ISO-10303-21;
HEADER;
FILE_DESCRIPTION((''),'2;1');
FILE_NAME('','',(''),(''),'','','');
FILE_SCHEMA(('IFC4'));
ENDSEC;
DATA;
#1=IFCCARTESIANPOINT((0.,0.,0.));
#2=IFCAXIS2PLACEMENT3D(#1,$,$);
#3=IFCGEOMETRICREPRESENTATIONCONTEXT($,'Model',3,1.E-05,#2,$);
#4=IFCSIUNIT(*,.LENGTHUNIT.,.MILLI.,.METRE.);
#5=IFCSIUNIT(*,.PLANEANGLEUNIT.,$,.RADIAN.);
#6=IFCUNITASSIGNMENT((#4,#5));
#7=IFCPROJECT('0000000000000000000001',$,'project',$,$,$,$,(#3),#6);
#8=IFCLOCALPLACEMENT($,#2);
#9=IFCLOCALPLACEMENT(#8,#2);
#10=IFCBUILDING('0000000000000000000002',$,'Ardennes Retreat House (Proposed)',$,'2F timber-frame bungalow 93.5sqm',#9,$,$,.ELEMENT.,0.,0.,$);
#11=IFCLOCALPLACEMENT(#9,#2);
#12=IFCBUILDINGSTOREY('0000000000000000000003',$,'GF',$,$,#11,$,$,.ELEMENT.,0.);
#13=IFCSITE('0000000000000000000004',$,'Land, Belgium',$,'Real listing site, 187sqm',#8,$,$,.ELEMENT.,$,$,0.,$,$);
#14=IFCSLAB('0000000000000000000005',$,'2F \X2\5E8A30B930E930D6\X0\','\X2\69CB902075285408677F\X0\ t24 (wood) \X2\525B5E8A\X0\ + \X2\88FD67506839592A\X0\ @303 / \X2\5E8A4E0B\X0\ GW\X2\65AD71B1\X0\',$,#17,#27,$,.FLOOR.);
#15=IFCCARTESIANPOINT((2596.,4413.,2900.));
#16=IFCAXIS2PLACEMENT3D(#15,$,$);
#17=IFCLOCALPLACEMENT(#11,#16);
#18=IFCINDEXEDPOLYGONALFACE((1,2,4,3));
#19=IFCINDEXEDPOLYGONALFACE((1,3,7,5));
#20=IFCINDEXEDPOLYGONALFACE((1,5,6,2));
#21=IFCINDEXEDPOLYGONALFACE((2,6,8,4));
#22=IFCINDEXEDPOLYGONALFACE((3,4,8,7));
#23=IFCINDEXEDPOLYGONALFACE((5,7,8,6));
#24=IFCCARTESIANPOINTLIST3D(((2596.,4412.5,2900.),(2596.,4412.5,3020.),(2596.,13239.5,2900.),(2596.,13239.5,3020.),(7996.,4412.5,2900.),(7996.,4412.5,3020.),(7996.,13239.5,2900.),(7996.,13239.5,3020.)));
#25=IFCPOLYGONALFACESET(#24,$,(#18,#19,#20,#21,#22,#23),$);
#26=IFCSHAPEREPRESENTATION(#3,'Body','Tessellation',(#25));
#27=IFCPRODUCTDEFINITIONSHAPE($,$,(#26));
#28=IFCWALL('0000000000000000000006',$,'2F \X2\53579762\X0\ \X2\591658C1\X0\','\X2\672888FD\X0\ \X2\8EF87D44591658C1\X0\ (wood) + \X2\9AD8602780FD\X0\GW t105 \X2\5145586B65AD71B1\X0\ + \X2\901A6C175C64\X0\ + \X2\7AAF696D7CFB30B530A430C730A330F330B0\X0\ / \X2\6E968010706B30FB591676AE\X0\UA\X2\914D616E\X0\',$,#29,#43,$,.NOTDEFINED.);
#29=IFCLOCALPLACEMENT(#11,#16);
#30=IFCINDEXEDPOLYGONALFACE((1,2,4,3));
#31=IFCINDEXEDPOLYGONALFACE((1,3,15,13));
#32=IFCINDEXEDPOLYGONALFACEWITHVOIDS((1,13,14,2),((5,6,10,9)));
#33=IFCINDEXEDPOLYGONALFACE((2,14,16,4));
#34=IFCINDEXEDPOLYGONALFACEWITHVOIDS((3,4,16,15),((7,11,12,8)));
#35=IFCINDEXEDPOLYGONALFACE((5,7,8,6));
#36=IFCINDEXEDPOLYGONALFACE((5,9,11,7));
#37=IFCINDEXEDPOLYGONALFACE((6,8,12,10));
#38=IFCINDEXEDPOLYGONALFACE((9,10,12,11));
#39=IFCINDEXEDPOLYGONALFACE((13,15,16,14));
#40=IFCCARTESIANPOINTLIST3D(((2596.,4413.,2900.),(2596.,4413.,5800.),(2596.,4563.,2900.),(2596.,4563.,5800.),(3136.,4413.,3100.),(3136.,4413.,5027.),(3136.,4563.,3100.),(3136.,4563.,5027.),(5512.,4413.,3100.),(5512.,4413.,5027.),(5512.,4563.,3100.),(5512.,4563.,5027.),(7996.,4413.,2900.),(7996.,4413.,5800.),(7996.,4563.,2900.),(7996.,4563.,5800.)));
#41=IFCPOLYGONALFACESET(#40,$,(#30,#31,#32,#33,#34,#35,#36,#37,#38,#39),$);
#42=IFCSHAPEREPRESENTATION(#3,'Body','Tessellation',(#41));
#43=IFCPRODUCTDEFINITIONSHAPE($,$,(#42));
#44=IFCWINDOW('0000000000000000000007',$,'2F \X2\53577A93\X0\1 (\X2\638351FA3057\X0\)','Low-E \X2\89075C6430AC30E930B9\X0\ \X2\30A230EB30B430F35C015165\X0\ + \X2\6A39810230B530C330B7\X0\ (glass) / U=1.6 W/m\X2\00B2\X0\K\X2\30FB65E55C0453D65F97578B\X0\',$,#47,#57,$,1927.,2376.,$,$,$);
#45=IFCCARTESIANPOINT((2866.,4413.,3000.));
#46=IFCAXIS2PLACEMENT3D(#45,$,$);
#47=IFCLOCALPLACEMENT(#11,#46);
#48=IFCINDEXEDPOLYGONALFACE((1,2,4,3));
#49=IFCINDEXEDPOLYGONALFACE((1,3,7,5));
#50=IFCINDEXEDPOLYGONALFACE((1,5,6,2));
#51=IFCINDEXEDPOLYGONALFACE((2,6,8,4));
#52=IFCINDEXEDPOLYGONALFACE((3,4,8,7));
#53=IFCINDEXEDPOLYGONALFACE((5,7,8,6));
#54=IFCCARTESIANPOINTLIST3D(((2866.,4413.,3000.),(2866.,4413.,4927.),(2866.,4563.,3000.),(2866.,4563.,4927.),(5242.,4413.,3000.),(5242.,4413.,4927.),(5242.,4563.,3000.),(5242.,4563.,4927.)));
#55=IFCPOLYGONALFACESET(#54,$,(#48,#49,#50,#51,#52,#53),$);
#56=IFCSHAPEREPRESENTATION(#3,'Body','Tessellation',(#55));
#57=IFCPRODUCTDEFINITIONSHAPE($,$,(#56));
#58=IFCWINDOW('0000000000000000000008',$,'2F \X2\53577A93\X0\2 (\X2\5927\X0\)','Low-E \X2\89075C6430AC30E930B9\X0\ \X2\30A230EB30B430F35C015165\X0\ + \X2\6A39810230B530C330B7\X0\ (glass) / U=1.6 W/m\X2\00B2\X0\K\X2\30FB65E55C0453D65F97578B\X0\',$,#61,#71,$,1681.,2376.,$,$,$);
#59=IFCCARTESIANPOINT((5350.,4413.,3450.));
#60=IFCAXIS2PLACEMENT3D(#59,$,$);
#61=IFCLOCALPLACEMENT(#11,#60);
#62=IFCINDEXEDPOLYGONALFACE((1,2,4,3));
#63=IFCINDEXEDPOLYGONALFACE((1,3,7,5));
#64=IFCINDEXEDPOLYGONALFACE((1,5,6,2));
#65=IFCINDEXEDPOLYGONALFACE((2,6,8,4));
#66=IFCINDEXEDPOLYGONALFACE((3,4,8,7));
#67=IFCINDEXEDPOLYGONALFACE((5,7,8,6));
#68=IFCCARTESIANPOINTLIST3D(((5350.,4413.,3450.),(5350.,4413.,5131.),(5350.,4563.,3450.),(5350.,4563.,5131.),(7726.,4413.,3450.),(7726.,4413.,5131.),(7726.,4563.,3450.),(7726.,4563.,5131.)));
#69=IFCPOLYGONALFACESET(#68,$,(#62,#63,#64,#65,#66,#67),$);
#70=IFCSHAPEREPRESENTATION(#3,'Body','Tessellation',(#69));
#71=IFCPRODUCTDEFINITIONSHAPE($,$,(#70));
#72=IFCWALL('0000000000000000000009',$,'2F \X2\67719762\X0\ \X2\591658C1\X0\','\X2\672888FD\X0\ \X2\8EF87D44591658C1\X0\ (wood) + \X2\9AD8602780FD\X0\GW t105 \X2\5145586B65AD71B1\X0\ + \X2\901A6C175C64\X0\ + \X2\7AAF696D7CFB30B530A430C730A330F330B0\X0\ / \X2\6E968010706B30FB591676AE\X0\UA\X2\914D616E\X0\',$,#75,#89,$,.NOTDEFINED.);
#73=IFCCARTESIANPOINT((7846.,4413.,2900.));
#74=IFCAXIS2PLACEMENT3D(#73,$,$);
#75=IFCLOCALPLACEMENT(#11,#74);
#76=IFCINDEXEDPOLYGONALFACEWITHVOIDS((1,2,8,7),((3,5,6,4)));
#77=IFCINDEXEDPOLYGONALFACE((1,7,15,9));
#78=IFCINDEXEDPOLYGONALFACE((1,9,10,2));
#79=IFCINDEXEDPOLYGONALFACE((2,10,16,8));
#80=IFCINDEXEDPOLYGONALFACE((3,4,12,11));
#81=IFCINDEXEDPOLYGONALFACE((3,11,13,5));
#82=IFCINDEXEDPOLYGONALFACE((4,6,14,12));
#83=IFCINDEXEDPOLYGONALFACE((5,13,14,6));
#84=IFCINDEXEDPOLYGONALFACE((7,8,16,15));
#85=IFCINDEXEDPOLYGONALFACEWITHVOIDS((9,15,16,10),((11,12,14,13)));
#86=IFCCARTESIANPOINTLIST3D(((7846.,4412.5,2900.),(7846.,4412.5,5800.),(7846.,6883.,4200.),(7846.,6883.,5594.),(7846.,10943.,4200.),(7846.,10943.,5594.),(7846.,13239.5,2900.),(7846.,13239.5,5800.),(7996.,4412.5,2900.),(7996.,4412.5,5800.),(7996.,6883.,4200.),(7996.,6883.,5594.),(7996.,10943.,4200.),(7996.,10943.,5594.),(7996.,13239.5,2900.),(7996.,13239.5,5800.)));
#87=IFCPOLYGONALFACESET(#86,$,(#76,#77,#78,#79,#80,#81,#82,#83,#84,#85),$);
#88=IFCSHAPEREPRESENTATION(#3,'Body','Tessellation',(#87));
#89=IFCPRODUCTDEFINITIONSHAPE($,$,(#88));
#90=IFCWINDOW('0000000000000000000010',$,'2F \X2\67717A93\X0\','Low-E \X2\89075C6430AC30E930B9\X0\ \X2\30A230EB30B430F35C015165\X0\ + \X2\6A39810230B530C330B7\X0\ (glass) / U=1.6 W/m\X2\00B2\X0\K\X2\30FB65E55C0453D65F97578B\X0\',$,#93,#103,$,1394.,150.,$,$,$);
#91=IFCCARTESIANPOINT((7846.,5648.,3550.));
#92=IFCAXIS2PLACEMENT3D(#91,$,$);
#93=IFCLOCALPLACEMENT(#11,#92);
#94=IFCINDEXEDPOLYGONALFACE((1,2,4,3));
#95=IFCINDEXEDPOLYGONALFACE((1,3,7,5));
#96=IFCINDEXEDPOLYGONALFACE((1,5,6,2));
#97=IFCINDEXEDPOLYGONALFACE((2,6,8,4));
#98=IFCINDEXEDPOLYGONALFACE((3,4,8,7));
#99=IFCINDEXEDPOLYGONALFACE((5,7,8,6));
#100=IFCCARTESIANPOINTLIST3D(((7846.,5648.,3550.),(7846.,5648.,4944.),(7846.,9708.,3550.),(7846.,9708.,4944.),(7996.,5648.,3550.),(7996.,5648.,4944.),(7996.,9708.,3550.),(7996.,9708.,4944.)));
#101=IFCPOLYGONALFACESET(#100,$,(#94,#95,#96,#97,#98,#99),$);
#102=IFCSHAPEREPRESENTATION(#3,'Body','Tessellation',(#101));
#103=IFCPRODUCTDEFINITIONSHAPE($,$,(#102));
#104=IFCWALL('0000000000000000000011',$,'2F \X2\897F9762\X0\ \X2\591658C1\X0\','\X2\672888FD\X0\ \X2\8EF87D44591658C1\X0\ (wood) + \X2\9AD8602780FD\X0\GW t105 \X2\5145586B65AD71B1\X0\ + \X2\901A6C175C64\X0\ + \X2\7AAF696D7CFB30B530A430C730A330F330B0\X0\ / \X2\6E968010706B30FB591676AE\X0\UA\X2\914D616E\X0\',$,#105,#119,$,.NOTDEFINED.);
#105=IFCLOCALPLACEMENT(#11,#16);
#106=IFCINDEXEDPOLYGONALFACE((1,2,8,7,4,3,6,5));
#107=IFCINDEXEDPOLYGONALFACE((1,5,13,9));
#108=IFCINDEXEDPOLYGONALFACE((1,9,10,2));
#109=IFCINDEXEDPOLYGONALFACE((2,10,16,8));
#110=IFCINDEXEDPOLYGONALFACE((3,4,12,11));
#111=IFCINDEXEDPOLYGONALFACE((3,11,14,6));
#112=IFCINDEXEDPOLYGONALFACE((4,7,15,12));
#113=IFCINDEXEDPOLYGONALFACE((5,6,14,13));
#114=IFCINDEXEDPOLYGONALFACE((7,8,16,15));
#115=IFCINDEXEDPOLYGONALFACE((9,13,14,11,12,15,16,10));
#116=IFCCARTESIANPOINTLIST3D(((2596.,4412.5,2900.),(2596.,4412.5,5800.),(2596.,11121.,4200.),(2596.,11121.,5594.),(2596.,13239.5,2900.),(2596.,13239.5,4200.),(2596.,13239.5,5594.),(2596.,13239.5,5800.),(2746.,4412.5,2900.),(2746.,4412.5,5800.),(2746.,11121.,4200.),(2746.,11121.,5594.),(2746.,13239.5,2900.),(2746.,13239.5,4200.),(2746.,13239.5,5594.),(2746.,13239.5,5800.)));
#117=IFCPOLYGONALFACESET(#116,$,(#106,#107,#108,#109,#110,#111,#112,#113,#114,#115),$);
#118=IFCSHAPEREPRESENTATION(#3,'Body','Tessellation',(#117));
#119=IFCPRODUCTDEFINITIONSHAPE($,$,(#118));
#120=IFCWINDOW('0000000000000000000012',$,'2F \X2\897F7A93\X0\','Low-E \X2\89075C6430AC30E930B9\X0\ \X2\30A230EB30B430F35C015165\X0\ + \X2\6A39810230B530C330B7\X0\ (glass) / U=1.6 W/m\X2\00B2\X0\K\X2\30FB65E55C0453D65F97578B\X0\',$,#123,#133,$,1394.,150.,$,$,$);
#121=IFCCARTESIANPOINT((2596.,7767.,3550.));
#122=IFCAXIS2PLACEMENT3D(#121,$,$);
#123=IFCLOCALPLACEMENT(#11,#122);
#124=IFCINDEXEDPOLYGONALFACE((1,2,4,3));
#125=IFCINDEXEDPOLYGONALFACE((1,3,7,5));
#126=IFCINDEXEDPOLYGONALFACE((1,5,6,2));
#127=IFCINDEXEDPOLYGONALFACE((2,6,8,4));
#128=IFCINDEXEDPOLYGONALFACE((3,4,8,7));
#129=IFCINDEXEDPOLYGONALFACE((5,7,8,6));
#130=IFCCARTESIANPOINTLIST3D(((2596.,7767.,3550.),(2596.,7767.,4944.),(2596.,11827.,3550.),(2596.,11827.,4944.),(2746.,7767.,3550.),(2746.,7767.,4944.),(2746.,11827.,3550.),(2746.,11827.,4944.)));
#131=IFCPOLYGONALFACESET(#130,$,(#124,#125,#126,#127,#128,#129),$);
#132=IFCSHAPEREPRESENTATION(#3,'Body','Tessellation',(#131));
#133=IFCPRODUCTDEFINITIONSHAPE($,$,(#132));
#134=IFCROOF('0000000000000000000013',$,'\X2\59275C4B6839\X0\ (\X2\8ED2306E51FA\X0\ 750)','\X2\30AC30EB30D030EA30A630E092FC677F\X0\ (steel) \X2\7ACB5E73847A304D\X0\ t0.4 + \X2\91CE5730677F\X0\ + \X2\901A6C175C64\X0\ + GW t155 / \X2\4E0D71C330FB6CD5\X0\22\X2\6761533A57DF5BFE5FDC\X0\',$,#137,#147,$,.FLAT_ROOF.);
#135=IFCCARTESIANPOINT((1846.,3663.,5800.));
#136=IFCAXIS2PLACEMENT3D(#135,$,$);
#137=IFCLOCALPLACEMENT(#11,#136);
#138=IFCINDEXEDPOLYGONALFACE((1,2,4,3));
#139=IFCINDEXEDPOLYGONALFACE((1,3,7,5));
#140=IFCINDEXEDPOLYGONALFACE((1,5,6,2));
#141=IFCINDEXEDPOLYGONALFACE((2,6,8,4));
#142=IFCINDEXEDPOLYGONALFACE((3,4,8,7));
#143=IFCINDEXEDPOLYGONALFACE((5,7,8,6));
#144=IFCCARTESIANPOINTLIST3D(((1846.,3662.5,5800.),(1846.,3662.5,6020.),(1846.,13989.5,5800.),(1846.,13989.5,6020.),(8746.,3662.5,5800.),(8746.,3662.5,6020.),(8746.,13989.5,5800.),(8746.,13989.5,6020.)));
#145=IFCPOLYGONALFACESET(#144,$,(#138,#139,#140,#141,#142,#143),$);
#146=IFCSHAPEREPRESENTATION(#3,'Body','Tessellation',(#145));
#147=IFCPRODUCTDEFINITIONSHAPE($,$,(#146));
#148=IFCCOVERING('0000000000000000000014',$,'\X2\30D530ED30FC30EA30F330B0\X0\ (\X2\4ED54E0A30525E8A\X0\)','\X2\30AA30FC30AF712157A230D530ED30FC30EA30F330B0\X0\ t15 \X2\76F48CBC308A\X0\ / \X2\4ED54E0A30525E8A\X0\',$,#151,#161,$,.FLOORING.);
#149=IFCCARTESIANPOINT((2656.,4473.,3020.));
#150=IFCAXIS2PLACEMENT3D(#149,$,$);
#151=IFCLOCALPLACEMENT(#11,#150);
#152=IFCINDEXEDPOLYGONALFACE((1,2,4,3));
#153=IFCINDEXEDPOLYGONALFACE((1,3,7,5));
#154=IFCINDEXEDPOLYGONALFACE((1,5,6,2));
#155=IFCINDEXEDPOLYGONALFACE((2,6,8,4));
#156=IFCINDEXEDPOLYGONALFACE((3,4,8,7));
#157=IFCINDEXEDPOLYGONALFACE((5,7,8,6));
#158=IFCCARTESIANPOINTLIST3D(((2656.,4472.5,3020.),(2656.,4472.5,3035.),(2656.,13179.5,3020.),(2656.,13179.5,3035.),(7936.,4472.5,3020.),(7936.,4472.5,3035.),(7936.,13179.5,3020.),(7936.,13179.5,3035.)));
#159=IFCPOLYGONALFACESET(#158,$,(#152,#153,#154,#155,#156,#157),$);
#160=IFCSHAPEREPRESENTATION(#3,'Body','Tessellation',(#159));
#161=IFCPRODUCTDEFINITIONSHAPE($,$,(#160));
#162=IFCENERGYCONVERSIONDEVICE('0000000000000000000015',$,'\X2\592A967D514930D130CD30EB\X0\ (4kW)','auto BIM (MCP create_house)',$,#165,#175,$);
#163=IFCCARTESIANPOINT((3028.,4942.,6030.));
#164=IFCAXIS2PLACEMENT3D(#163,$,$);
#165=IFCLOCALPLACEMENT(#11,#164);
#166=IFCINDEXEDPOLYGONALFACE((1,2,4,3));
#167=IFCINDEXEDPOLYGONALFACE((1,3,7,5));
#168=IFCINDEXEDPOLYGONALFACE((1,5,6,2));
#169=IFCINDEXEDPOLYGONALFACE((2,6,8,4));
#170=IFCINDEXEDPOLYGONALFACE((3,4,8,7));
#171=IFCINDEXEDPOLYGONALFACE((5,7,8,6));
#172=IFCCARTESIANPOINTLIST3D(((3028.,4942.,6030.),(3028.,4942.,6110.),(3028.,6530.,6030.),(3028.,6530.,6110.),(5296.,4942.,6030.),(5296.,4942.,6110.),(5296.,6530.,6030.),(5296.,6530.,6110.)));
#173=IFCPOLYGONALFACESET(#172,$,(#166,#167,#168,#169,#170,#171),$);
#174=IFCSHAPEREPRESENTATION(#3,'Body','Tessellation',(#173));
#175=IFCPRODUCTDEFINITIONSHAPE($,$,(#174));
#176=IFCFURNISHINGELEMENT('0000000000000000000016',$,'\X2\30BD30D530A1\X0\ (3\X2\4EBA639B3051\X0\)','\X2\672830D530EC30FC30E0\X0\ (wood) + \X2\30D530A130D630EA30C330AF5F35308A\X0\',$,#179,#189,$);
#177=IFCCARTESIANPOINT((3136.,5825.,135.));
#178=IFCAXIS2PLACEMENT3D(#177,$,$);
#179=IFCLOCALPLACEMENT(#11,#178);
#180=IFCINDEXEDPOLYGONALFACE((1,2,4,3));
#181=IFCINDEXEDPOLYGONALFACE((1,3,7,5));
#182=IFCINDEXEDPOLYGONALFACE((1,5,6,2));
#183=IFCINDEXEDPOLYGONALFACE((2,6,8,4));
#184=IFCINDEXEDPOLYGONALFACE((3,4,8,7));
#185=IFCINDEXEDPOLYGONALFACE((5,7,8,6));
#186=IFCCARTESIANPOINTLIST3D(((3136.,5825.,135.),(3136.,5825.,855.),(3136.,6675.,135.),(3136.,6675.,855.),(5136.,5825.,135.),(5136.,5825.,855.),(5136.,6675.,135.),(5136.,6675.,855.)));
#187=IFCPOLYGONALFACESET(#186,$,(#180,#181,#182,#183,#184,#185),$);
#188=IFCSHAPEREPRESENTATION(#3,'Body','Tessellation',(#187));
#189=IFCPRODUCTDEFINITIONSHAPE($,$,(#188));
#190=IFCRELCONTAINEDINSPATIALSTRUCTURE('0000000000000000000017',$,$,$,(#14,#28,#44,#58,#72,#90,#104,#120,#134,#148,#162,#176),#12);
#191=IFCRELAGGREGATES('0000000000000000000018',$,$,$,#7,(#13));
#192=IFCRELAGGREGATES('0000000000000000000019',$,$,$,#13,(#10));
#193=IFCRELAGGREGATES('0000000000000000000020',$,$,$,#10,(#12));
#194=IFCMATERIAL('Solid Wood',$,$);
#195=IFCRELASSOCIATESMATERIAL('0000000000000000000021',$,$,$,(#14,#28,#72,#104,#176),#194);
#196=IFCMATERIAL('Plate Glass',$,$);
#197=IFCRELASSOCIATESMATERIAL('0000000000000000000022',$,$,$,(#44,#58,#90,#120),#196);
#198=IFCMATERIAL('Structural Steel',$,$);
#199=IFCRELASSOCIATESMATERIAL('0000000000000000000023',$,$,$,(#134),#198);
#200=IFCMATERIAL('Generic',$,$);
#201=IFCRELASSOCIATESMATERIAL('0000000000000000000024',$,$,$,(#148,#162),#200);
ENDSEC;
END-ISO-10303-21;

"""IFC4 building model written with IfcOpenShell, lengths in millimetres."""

from ifc_helpers import new_model, si_unit, frame, frame_2d, origin, place, context, project, spatial, rectangle, extrude, material, element, fill, save


model = new_model("IFC4")

# Units and contexts
model_context = context("Model", 3, precision=1e-05, world=origin())
ifc_project = project(units=[si_unit("LENGTHUNIT", "METRE", prefix="MILLI"), si_unit("PLANEANGLEUNIT", "RADIAN")], contexts=[model_context])

# Site, building, storey
site_placement = place(None, origin())
site = spatial("IfcSite", under=ifc_project, at=site_placement, Name="Land, Belgium", ObjectType="Real listing site, 187sqm", CompositionType="ELEMENT", RefElevation=0.0)
building_placement = place(site_placement, origin())
building = spatial("IfcBuilding", under=site, at=building_placement, Name="Ardennes Retreat House (Proposed)", ObjectType="2F timber-frame bungalow 93.5sqm", CompositionType="ELEMENT", ElevationOfRefHeight=0.0, ElevationOfTerrain=0.0)
storey_placement = place(building_placement, origin())
storey = spatial("IfcBuildingStorey", under=building, at=storey_placement, Name="GF", CompositionType="ELEMENT", Elevation=0.0)

# Slab
ifc_material_1 = material(Name="Solid Wood")
slab_placement = place(storey_placement, frame((2596.0, 4413.0, 2900.0)))
element("IfcSlab", 1, at=slab_placement, inside=storey, material=ifc_material_1, Name="2F 床スラブ", Description="構造用合板 t24 (wood) 剛床 + 製材根太 @303 / 床下 GW断熱", PredefinedType="FLOOR", context=model_context, shape_type="SweptSolid", body=[
    extrude(rectangle(XDim=5400.0, YDim=8827.0, at=frame_2d((2700.0, 4413.0))), frame((2596.0, 4413.0, 2900.0)), (0.0, 0.0, 1.0), 120.0),
])

# Wall, openings, windows
wall_1_placement = place(storey_placement, frame((2596.0, 4413.0, 2900.0)))
wall_1 = element("IfcWall", 2, at=wall_1_placement, inside=storey, material=ifc_material_1, Name="2F 南面 外壁", Description="木製 軸組外壁 (wood) + 高性能GW t105 充填断熱 + 通気層 + 窯業系サイディング / 準耐火・外皮UA配慮", PredefinedType="NOTDEFINED", context=model_context, shape_type="SweptSolid", body=[
    extrude(rectangle(XDim=5400.0, YDim=150.0, at=frame_2d((2700.0, 75.0))), frame((2596.0, 4413.0, 2900.0)), (0.0, 0.0, 1.0), 2900.0),
])
opening_1_placement = place(storey_placement, frame((2866.0, 4413.0, 3000.0)))
opening_1 = element("IfcOpeningElement", 3, at=opening_1_placement, cuts=wall_1, PredefinedType="NOTDEFINED", context=model_context, shape_type="SweptSolid", body=[
    extrude(rectangle(XDim=2376.0, YDim=150.0, at=frame_2d((1188.0, 75.0))), frame((2866.0, 4413.0, 3000.0)), (0.0, 0.0, 1.0), 1927.0),
])
opening_2_placement = place(storey_placement, frame((5350.0, 4413.0, 3450.0)))
opening_2 = element("IfcOpeningElement", 4, at=opening_2_placement, cuts=wall_1, PredefinedType="NOTDEFINED", context=model_context, shape_type="SweptSolid", body=[
    extrude(rectangle(XDim=2376.0, YDim=150.0, at=frame_2d((1188.0, 75.0))), frame((5350.0, 4413.0, 3450.0)), (0.0, 0.0, 1.0), 1681.0),
])
ifc_material_2 = material(Name="Plate Glass")
window_1_placement = place(storey_placement, frame((2866.0, 4413.0, 3000.0)))
window_1 = element("IfcWindow", 5, at=window_1_placement, inside=storey, material=ifc_material_2, Name="2F 南窓1 (掃出し)", Description="Low-E 複層ガラス アルゴン封入 + 樹脂サッシ (glass) / U=1.6 W/m²K・日射取得型", OverallHeight=1927.0, OverallWidth=2376.0, context=model_context, shape_type="SweptSolid", body=[
    extrude(rectangle(XDim=2376.0, YDim=150.0, at=frame_2d((1188.0, 75.0))), frame((2866.0, 4413.0, 3000.0)), (0.0, 0.0, 1.0), 1927.0),
])
fill(opening_1, window_1)
window_2_placement = place(storey_placement, frame((5350.0, 4413.0, 3450.0)))
window_2 = element("IfcWindow", 6, at=window_2_placement, inside=storey, material=ifc_material_2, Name="2F 南窓2 (大)", Description="Low-E 複層ガラス アルゴン封入 + 樹脂サッシ (glass) / U=1.6 W/m²K・日射取得型", OverallHeight=1681.0, OverallWidth=2376.0, context=model_context, shape_type="SweptSolid", body=[
    extrude(rectangle(XDim=2376.0, YDim=150.0, at=frame_2d((1188.0, 75.0))), frame((5350.0, 4413.0, 3450.0)), (0.0, 0.0, 1.0), 1681.0),
])
fill(opening_2, window_2)

# Walls, openings, windows
wall_2_placement = place(storey_placement, frame((7846.0, 4413.0, 2900.0)))
wall_2 = element("IfcWall", 7, at=wall_2_placement, inside=storey, material=ifc_material_1, Name="2F 東面 外壁", Description="木製 軸組外壁 (wood) + 高性能GW t105 充填断熱 + 通気層 + 窯業系サイディング / 準耐火・外皮UA配慮", PredefinedType="NOTDEFINED", context=model_context, shape_type="SweptSolid", body=[
    extrude(rectangle(XDim=150.0, YDim=8827.0, at=frame_2d((75.0, 4413.0))), frame((7846.0, 4413.0, 2900.0)), (0.0, 0.0, 1.0), 2900.0),
])
opening_3_placement = place(storey_placement, frame((7846.0, 5648.0, 3550.0)))
opening_3 = element("IfcOpeningElement", 8, at=opening_3_placement, cuts=wall_2, PredefinedType="NOTDEFINED", context=model_context, shape_type="SweptSolid", body=[
    extrude(rectangle(XDim=150.0, YDim=4060.0, at=frame_2d((75.0, 2030.0))), frame((7846.0, 5648.0, 3550.0)), (0.0, 0.0, 1.0), 1394.0),
])
window_3_placement = place(storey_placement, frame((7846.0, 5648.0, 3550.0)))
window_3 = element("IfcWindow", 9, at=window_3_placement, inside=storey, material=ifc_material_2, Name="2F 東窓", Description="Low-E 複層ガラス アルゴン封入 + 樹脂サッシ (glass) / U=1.6 W/m²K・日射取得型", OverallHeight=1394.0, OverallWidth=150.0, context=model_context, shape_type="SweptSolid", body=[
    extrude(rectangle(XDim=150.0, YDim=4060.0, at=frame_2d((75.0, 2030.0))), frame((7846.0, 5648.0, 3550.0)), (0.0, 0.0, 1.0), 1394.0),
])
fill(opening_3, window_3)
wall_3_placement = place(storey_placement, frame((2596.0, 4413.0, 2900.0)))
wall_3 = element("IfcWall", 10, at=wall_3_placement, inside=storey, material=ifc_material_1, Name="2F 西面 外壁", Description="木製 軸組外壁 (wood) + 高性能GW t105 充填断熱 + 通気層 + 窯業系サイディング / 準耐火・外皮UA配慮", PredefinedType="NOTDEFINED", context=model_context, shape_type="SweptSolid", body=[
    extrude(rectangle(XDim=150.0, YDim=8827.0, at=frame_2d((75.0, 4413.0))), frame((2596.0, 4413.0, 2900.0)), (0.0, 0.0, 1.0), 2900.0),
])
opening_4_placement = place(storey_placement, frame((2596.0, 7767.0, 3550.0)))
opening_4 = element("IfcOpeningElement", 11, at=opening_4_placement, cuts=wall_3, PredefinedType="NOTDEFINED", context=model_context, shape_type="SweptSolid", body=[
    extrude(rectangle(XDim=150.0, YDim=4060.0, at=frame_2d((75.0, 2030.0))), frame((2596.0, 7767.0, 3550.0)), (0.0, 0.0, 1.0), 1394.0),
])
window_4_placement = place(storey_placement, frame((2596.0, 7767.0, 3550.0)))
window_4 = element("IfcWindow", 12, at=window_4_placement, inside=storey, material=ifc_material_2, Name="2F 西窓", Description="Low-E 複層ガラス アルゴン封入 + 樹脂サッシ (glass) / U=1.6 W/m²K・日射取得型", OverallHeight=1394.0, OverallWidth=150.0, context=model_context, shape_type="SweptSolid", body=[
    extrude(rectangle(XDim=150.0, YDim=4060.0, at=frame_2d((75.0, 2030.0))), frame((2596.0, 7767.0, 3550.0)), (0.0, 0.0, 1.0), 1394.0),
])
fill(opening_4, window_4)

# Roof
ifc_material_3 = material(Name="Structural Steel")
roof_placement = place(storey_placement, frame((1846.0, 3663.0, 5800.0)))
element("IfcRoof", 13, at=roof_placement, inside=storey, material=ifc_material_3, Name="大屋根 (軒の出 750)", Description="ガルバリウム鋼板 (steel) 立平葺き t0.4 + 野地板 + 通気層 + GW t155 / 不燃・法22条区域対応", PredefinedType="FLAT_ROOF", context=model_context, shape_type="SweptSolid", body=[
    extrude(rectangle(XDim=6900.0, YDim=10327.0, at=frame_2d((3450.0, 5163.0))), frame((1846.0, 3663.0, 5800.0)), (0.0, 0.0, 1.0), 220.0),
])

# Covering
ifc_material_4 = material(Name="Generic")
covering_placement = place(storey_placement, frame((2656.0, 4473.0, 3020.0)))
element("IfcCovering", 14, at=covering_placement, inside=storey, material=ifc_material_4, Name="フローリング (仕上げ床)", Description="オーク無垢フローリング t15 直貼り / 仕上げ床", PredefinedType="FLOORING", context=model_context, shape_type="SweptSolid", body=[
    extrude(rectangle(XDim=5280.0, YDim=8707.0, at=frame_2d((2640.0, 4353.0))), frame((2656.0, 4473.0, 3020.0)), (0.0, 0.0, 1.0), 15.0),
])

# Energy conversion device
energy_conversion_device_placement = place(storey_placement, frame((3028.0, 4942.0, 6030.0)))
element("IfcEnergyConversionDevice", 15, at=energy_conversion_device_placement, inside=storey, material=ifc_material_4, Name="太陽光パネル (4kW)", Description="auto BIM (MCP create_house)", context=model_context, shape_type="SweptSolid", body=[
    extrude(rectangle(XDim=2268.0, YDim=1588.0, at=frame_2d((1134.0, 794.0))), frame((3028.0, 4942.0, 6030.0)), (0.0, 0.0, 1.0), 80.0),
])

# Furnishing element
furnishing_1_placement = place(storey_placement, frame((3136.0, 5825.0, 135.0)))
element("IfcFurnishingElement", 16, at=furnishing_1_placement, inside=storey, material=ifc_material_1, Name="ソファ (3人掛け)", Description="木フレーム (wood) + ファブリック張り", context=model_context, shape_type="SweptSolid", body=[
    extrude(rectangle(XDim=2000.0, YDim=850.0, at=frame_2d((1000.0, 425.0))), frame((3136.0, 5825.0, 135.0)), (0.0, 0.0, 1.0), 720.0),
])

save(model, "model.ifc")
